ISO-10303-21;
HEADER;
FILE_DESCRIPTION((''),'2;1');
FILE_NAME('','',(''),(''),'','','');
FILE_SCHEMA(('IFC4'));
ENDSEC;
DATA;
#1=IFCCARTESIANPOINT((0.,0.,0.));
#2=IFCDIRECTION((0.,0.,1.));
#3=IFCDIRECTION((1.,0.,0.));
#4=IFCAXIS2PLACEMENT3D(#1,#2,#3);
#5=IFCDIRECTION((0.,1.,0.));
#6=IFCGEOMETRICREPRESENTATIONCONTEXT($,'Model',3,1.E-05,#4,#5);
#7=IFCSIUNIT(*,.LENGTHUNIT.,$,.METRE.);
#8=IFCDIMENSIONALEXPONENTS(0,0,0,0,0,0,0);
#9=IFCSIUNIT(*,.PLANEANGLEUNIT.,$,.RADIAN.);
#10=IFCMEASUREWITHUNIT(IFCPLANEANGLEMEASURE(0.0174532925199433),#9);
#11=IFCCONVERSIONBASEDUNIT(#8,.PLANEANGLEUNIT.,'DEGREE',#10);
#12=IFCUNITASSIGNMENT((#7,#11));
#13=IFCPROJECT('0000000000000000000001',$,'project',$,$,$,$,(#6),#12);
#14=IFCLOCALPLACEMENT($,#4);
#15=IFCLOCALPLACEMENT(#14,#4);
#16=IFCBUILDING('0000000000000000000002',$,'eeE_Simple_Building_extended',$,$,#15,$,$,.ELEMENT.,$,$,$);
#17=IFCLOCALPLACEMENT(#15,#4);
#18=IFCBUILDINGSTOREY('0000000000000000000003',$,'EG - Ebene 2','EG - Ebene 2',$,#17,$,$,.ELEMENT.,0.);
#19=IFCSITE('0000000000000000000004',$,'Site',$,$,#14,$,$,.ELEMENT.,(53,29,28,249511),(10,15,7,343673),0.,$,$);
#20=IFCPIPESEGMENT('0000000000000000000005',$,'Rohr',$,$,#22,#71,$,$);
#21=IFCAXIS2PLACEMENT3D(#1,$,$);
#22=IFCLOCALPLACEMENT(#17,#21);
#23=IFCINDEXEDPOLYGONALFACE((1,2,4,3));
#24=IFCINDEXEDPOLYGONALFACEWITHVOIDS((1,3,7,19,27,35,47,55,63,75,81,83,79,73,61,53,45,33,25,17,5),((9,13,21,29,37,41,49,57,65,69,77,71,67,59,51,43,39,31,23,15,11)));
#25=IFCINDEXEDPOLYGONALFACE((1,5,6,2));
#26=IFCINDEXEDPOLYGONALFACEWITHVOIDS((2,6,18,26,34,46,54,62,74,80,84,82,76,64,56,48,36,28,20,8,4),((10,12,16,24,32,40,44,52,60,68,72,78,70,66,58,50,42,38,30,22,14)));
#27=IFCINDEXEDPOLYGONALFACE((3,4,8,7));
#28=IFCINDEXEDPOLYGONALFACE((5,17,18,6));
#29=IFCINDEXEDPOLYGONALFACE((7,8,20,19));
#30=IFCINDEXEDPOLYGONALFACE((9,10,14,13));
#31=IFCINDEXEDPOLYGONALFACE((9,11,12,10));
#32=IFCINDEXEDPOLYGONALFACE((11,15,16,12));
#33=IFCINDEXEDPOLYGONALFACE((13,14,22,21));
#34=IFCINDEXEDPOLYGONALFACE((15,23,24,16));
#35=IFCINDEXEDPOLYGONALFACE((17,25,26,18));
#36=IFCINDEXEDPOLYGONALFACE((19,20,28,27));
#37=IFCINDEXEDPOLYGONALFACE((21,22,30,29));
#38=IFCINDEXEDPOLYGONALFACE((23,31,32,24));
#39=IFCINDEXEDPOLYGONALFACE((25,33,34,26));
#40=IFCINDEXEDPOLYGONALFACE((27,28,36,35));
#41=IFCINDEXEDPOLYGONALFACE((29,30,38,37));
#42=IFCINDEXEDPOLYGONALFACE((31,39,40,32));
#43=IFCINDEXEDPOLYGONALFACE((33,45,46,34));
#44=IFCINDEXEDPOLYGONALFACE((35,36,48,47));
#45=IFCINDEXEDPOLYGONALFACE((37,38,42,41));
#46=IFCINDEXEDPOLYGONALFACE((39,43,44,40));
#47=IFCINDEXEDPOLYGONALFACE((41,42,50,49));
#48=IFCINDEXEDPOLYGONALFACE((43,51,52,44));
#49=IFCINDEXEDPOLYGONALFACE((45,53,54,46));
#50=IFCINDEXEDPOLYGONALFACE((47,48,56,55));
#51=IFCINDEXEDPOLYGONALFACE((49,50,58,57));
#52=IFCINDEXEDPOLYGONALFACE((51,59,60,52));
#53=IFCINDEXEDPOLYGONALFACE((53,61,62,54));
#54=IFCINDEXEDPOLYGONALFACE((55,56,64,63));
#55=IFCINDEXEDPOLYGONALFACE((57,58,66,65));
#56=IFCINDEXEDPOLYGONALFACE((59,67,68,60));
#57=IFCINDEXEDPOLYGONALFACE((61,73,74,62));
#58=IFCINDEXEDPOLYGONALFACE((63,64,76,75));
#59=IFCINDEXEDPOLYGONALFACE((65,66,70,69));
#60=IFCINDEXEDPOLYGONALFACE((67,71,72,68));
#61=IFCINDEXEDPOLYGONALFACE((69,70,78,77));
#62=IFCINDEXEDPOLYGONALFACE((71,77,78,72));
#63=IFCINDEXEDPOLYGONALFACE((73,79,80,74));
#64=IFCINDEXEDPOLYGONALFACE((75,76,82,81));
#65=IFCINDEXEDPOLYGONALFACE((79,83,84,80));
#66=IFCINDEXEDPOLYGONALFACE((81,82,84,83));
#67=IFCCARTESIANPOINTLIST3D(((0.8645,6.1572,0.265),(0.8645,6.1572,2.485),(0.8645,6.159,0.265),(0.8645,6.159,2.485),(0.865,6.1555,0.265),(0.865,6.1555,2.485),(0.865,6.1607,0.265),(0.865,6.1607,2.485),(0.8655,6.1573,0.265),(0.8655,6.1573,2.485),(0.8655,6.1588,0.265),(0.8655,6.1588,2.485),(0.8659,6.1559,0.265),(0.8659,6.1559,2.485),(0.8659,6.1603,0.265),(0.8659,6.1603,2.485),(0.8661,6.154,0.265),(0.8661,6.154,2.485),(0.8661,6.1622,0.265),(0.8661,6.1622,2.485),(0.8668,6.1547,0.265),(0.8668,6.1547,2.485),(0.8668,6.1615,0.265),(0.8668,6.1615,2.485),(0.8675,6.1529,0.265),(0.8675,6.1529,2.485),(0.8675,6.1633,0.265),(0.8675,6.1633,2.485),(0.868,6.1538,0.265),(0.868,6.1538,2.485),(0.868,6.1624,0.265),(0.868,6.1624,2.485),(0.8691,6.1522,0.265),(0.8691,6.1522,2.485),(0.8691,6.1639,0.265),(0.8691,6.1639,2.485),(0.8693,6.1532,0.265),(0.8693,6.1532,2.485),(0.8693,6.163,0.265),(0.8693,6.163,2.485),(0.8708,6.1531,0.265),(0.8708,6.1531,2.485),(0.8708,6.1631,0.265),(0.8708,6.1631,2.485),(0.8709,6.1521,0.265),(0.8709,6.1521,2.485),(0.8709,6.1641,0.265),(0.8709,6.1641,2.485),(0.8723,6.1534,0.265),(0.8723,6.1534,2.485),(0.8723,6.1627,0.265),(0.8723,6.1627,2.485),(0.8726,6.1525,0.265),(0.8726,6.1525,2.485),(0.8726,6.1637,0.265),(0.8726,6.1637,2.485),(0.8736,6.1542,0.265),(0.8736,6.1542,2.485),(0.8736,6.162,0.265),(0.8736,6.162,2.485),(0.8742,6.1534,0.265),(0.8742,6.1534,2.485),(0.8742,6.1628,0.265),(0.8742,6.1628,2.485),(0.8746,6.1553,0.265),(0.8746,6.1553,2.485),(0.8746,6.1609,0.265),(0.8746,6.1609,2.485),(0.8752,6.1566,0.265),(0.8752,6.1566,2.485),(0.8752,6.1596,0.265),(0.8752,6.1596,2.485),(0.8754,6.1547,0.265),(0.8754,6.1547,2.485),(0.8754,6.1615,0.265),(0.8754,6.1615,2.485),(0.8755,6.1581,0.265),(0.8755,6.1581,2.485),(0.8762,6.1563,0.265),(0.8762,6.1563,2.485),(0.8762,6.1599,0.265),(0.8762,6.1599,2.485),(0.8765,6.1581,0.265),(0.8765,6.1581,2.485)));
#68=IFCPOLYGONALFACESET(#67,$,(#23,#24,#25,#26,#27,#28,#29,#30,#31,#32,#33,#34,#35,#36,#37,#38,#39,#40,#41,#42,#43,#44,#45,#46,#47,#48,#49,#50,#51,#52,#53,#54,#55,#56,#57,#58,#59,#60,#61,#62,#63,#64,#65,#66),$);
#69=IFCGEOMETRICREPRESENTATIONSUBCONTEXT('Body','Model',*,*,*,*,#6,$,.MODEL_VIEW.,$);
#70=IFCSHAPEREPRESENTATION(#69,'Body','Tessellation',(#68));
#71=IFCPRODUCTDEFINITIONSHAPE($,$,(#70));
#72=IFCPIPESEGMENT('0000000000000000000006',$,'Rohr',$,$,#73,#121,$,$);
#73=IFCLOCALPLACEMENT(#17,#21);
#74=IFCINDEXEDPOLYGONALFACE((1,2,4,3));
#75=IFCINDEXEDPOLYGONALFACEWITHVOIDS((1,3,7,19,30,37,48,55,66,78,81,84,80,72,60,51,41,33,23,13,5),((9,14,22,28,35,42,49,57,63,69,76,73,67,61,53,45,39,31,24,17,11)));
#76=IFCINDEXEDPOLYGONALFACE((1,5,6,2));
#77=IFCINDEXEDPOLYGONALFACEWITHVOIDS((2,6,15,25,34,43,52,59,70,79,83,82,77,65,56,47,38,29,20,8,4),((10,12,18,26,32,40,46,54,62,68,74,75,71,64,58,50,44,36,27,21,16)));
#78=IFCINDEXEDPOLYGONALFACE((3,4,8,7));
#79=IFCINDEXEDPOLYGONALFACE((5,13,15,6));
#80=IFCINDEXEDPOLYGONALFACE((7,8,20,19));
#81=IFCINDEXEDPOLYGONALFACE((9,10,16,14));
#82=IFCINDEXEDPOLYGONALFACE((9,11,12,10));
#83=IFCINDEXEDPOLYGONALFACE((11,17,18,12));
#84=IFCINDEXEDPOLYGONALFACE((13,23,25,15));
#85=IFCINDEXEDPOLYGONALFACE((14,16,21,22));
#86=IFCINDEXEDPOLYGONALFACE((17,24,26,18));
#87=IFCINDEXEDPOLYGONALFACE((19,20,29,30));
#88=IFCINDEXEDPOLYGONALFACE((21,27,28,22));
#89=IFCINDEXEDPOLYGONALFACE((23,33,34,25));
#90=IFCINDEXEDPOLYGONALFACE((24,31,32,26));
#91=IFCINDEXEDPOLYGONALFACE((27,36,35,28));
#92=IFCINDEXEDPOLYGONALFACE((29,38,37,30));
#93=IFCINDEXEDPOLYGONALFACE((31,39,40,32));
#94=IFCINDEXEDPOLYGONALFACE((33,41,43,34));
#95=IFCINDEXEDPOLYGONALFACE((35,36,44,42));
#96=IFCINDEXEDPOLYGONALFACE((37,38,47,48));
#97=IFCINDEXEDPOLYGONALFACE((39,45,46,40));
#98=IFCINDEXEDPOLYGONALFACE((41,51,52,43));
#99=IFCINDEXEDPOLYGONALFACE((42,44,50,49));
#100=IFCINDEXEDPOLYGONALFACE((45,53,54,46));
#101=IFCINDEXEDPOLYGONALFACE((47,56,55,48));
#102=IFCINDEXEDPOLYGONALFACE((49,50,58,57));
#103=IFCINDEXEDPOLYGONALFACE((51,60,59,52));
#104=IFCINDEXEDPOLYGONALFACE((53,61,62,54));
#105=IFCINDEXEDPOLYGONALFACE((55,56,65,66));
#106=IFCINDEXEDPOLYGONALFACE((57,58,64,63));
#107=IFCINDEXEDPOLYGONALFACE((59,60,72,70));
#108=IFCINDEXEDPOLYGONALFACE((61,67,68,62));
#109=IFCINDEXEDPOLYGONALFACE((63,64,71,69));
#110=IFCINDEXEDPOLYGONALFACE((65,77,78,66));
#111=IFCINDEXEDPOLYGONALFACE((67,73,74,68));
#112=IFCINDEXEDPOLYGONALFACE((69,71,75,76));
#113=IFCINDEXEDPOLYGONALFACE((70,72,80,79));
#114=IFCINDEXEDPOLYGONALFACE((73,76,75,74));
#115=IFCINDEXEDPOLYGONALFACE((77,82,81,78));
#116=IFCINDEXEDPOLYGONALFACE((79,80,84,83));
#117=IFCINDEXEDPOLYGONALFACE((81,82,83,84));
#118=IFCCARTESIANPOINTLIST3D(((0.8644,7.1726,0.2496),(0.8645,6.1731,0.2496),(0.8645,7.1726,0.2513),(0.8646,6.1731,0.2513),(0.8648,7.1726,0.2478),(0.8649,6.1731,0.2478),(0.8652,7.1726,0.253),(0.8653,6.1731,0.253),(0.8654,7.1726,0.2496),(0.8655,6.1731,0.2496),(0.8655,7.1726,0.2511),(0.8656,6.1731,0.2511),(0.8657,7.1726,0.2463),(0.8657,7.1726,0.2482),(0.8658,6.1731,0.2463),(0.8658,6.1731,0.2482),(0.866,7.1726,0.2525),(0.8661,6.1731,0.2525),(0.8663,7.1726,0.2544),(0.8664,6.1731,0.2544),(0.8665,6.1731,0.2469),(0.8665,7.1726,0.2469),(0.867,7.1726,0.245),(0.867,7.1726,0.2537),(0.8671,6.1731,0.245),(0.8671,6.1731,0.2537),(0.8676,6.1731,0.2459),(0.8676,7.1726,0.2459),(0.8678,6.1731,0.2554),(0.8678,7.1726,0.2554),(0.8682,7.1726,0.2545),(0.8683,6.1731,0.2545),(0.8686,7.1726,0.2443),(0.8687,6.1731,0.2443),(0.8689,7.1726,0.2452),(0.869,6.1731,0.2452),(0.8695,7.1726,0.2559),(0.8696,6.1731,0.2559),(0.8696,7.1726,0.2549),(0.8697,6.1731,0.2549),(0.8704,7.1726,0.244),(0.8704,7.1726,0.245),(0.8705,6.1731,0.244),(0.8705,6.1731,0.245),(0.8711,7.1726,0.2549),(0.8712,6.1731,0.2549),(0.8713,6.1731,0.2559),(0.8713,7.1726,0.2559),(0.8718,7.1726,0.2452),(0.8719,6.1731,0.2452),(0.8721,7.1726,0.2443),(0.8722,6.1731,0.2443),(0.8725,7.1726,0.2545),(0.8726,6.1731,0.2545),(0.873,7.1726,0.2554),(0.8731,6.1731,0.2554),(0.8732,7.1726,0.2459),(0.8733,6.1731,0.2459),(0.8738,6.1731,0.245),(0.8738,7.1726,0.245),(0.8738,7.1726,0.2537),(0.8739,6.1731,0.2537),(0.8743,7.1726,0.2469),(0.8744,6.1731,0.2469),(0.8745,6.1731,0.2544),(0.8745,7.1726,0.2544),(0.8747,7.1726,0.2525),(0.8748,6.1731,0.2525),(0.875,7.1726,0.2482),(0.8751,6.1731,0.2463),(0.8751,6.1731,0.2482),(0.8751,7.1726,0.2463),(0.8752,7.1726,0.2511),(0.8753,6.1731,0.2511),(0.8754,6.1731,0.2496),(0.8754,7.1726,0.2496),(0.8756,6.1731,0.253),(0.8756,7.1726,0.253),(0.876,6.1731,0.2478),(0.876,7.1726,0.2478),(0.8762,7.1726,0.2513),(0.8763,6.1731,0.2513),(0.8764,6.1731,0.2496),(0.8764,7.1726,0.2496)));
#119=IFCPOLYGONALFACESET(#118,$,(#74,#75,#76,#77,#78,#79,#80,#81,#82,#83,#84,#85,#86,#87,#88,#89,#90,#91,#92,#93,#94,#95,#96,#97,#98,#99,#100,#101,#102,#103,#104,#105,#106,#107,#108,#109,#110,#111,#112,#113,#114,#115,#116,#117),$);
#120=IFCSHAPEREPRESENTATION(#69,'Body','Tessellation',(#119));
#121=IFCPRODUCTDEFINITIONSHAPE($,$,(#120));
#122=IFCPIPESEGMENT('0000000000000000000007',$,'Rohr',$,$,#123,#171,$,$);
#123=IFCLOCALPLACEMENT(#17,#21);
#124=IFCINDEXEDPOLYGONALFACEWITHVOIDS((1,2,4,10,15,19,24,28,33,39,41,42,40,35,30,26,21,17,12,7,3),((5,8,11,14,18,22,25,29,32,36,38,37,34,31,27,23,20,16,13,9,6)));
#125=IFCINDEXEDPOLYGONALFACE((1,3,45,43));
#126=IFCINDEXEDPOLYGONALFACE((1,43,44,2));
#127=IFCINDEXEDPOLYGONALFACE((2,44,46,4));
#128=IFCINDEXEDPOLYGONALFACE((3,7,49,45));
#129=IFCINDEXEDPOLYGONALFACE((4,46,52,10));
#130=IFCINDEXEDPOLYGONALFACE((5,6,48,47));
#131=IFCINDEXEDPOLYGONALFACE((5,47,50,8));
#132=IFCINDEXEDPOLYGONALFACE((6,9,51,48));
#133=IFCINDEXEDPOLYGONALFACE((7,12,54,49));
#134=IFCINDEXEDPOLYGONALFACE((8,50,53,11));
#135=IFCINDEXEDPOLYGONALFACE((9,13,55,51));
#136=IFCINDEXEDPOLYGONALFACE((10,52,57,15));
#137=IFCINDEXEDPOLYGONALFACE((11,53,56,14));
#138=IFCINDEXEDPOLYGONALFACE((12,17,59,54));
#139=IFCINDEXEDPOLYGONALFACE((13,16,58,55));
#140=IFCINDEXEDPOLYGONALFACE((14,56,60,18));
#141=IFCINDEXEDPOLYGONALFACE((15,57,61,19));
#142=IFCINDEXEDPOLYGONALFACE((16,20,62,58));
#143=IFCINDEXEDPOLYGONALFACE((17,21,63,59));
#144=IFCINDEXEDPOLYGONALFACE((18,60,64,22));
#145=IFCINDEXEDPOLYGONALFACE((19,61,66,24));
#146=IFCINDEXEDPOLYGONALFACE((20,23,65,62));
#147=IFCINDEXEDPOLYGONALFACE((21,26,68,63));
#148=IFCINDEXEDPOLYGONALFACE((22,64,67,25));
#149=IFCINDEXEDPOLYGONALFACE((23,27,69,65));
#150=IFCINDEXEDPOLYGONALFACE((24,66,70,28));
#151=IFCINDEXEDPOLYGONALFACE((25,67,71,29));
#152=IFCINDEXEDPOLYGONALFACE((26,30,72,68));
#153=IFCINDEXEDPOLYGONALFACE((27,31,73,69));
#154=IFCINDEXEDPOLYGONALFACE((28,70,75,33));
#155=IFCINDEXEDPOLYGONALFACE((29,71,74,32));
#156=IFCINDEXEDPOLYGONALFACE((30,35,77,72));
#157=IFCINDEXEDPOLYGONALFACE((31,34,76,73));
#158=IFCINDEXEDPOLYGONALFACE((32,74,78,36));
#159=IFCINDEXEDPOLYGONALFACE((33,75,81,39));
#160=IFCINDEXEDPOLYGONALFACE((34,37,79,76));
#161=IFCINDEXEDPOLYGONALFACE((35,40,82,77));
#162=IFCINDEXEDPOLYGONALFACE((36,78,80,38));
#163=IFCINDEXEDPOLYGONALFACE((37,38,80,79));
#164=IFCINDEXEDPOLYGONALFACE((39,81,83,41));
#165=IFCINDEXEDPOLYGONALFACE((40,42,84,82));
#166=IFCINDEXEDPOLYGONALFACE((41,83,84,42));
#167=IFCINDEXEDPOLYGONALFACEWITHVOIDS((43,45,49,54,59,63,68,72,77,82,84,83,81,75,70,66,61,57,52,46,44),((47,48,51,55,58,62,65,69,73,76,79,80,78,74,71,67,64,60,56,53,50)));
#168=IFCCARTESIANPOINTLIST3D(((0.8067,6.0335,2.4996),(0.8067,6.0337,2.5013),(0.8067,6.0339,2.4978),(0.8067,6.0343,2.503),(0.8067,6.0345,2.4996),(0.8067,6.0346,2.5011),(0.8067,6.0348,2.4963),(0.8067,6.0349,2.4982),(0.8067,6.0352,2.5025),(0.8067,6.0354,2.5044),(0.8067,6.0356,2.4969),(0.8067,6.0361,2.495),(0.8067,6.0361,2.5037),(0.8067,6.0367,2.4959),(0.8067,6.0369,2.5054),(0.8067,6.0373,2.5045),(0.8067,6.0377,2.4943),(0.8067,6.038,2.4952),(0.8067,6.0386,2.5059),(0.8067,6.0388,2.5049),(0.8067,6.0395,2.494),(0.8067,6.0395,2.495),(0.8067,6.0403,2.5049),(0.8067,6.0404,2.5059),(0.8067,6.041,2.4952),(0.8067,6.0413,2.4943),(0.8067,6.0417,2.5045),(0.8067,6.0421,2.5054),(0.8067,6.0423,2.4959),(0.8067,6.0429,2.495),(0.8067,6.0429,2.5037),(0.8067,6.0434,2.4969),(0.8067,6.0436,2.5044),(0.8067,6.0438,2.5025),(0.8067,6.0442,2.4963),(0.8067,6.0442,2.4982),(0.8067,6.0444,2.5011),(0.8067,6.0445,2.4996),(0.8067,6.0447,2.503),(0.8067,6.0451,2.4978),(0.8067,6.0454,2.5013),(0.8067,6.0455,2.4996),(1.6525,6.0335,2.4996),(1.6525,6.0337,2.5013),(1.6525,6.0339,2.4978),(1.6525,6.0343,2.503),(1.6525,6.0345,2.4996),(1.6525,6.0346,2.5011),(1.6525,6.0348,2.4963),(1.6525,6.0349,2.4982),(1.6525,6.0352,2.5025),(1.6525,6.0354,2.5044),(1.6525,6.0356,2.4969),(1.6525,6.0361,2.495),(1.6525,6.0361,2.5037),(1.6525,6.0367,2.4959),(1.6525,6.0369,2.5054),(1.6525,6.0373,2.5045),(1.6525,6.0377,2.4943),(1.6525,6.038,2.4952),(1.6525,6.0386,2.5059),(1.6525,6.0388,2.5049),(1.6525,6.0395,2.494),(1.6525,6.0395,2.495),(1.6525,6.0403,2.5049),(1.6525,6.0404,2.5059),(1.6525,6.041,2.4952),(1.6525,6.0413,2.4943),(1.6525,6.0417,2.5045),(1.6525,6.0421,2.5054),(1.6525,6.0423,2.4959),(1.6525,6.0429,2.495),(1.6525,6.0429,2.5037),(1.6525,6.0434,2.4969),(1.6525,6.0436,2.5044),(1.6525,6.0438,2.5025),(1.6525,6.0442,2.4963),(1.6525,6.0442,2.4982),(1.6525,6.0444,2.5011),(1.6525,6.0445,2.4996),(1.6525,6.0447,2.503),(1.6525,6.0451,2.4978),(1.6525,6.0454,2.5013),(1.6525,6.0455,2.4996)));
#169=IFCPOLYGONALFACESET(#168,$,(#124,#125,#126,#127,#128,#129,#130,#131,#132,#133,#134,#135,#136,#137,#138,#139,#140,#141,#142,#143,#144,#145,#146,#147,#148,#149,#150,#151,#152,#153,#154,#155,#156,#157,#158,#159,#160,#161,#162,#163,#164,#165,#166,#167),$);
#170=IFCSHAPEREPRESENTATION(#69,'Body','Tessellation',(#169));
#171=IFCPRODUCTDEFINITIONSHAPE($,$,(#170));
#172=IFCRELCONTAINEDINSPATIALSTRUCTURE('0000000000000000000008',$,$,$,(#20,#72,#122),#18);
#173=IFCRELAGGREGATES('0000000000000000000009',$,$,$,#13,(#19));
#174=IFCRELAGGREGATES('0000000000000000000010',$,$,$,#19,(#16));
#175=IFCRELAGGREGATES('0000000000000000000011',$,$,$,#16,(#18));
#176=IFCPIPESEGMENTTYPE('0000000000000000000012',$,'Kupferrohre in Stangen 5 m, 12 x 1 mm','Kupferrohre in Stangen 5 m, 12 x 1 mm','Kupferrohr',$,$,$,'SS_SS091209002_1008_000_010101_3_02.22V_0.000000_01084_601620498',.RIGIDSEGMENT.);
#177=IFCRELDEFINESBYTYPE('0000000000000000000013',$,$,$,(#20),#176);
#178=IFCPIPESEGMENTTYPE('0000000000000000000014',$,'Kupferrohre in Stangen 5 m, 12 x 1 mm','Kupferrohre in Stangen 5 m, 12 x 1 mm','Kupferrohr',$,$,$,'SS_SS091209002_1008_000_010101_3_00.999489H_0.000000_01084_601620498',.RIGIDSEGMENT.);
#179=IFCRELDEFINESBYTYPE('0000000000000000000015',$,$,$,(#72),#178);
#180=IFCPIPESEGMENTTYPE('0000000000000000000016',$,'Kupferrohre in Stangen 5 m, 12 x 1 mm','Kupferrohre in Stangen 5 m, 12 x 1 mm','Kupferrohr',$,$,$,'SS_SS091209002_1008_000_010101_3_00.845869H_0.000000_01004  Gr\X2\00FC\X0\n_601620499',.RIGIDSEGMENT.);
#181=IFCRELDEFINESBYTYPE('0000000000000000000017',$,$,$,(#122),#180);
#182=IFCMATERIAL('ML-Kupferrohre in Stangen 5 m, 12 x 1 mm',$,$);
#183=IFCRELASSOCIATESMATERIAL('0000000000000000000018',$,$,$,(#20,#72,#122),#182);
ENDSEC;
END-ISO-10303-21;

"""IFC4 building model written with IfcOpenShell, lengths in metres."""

from ifc_helpers import new_model, entity, si_unit, converted_unit, direction, frame, origin_with_axes, origin_2d_with_axis, place, context, subcontext, project, spatial, hollow_circle, extrude, material, type_object, element, save


model = new_model("IFC4")

# Units and contexts
model_context = context("Model", 3, precision=1e-05, world=origin_with_axes(), true_north=direction((0.0, 1.0, 0.0)))
body_context = subcontext(model_context, "Body", "Model", "MODEL_VIEW")
ifc_project = project(units=[si_unit("LENGTHUNIT", "METRE"), converted_unit("PLANEANGLEUNIT", "DEGREE", entity("IfcPlaneAngleMeasure", 0.0174532925199433), si_unit("PLANEANGLEUNIT", "RADIAN"), dimensions=[0, 0, 0, 0, 0, 0, 0])], contexts=[model_context])

# Site, building, storey
site_placement = place(None, origin_with_axes())
site = spatial("IfcSite", under=ifc_project, at=site_placement, Name="Site", CompositionType="ELEMENT", RefLatitude=(53, 29, 28, 249511), RefLongitude=(10, 15, 7, 343673), RefElevation=0.0)
building_placement = place(site_placement, origin_with_axes())
building = spatial("IfcBuilding", under=site, at=building_placement, Name="eeE_Simple_Building_extended", CompositionType="ELEMENT")
storey_placement = place(building_placement, origin_with_axes())
storey = spatial("IfcBuildingStorey", under=building, at=storey_placement, Name="EG - Ebene 2", Description="EG - Ebene 2", CompositionType="ELEMENT", Elevation=0.0)

# Pipe segments
ifc_material_1 = material(Name="ML-Kupferrohre in Stangen 5 m, 12 x 1 mm")
pipe_segment_type_1 = type_object("IfcPipeSegmentType", Name="Kupferrohre in Stangen 5 m, 12 x 1 mm", Description="Kupferrohre in Stangen 5 m, 12 x 1 mm", ApplicableOccurrence="Kupferrohr", ElementType="SS_SS091209002_1008_000_010101_3_02.22V_0.000000_01084_601620498", PredefinedType="RIGIDSEGMENT")
pipe_segment_1_placement = place(storey_placement, frame((0.8705, 6.1581, 2.485), z_axis=(-1.0, 0.0, 0.0), x_axis=(0.0, 0.0, -1.0)))
element("IfcPipeSegment", 1, at=pipe_segment_1_placement, inside=storey, type_object=pipe_segment_type_1, material=ifc_material_1, Name="Rohr", context=body_context, shape_type="SweptSolid", body=[
    extrude(hollow_circle(Radius=0.006, WallThickness=0.001, at=origin_2d_with_axis()), frame((0.0, 0.0, 0.0), z_axis=(1.0, 0.0, 0.0), x_axis=(0.0, 0.0, -1.0)), (0.0, 0.0, 1.0), 2.22),
])
pipe_segment_type_2 = type_object("IfcPipeSegmentType", Name="Kupferrohre in Stangen 5 m, 12 x 1 mm", Description="Kupferrohre in Stangen 5 m, 12 x 1 mm", ApplicableOccurrence="Kupferrohr", ElementType="SS_SS091209002_1008_000_010101_3_00.999489H_0.000000_01084_601620498", PredefinedType="RIGIDSEGMENT")
pipe_segment_2_placement = place(storey_placement, frame((0.8705, 6.1731, 0.25), z_axis=(0.0, 0.0, 1.0), x_axis=(-0.000082, 1.0, 0.0)))
element("IfcPipeSegment", 2, at=pipe_segment_2_placement, inside=storey, type_object=pipe_segment_type_2, material=ifc_material_1, Name="Rohr", context=body_context, shape_type="SweptSolid", body=[
    extrude(hollow_circle(Radius=0.006, WallThickness=0.001, at=origin_2d_with_axis()), frame((0.0, 0.0, 0.0), z_axis=(1.0, 0.0, 0.0), x_axis=(0.0, 0.0, -1.0)), (0.0, 0.0, 1.0), 0.9995),
])
pipe_segment_type_3 = type_object("IfcPipeSegmentType", Name="Kupferrohre in Stangen 5 m, 12 x 1 mm", Description="Kupferrohre in Stangen 5 m, 12 x 1 mm", ApplicableOccurrence="Kupferrohr", ElementType="SS_SS091209002_1008_000_010101_3_00.845869H_0.000000_01004  Grün_601620499", PredefinedType="RIGIDSEGMENT")
pipe_segment_3_placement = place(storey_placement, frame((1.6525, 6.0395, 2.5), z_axis=(0.0, 0.0, 1.0), x_axis=(-1.0, 0.0, 0.0)))
element("IfcPipeSegment", 3, at=pipe_segment_3_placement, inside=storey, type_object=pipe_segment_type_3, material=ifc_material_1, Name="Rohr", context=body_context, shape_type="SweptSolid", body=[
    extrude(hollow_circle(Radius=0.006, WallThickness=0.001, at=origin_2d_with_axis()), frame((0.0, 0.0, 0.0), z_axis=(1.0, 0.0, 0.0), x_axis=(0.0, 0.0, -1.0)), (0.0, 0.0, 1.0), 0.8459),
])

save(model, "model.ifc")
